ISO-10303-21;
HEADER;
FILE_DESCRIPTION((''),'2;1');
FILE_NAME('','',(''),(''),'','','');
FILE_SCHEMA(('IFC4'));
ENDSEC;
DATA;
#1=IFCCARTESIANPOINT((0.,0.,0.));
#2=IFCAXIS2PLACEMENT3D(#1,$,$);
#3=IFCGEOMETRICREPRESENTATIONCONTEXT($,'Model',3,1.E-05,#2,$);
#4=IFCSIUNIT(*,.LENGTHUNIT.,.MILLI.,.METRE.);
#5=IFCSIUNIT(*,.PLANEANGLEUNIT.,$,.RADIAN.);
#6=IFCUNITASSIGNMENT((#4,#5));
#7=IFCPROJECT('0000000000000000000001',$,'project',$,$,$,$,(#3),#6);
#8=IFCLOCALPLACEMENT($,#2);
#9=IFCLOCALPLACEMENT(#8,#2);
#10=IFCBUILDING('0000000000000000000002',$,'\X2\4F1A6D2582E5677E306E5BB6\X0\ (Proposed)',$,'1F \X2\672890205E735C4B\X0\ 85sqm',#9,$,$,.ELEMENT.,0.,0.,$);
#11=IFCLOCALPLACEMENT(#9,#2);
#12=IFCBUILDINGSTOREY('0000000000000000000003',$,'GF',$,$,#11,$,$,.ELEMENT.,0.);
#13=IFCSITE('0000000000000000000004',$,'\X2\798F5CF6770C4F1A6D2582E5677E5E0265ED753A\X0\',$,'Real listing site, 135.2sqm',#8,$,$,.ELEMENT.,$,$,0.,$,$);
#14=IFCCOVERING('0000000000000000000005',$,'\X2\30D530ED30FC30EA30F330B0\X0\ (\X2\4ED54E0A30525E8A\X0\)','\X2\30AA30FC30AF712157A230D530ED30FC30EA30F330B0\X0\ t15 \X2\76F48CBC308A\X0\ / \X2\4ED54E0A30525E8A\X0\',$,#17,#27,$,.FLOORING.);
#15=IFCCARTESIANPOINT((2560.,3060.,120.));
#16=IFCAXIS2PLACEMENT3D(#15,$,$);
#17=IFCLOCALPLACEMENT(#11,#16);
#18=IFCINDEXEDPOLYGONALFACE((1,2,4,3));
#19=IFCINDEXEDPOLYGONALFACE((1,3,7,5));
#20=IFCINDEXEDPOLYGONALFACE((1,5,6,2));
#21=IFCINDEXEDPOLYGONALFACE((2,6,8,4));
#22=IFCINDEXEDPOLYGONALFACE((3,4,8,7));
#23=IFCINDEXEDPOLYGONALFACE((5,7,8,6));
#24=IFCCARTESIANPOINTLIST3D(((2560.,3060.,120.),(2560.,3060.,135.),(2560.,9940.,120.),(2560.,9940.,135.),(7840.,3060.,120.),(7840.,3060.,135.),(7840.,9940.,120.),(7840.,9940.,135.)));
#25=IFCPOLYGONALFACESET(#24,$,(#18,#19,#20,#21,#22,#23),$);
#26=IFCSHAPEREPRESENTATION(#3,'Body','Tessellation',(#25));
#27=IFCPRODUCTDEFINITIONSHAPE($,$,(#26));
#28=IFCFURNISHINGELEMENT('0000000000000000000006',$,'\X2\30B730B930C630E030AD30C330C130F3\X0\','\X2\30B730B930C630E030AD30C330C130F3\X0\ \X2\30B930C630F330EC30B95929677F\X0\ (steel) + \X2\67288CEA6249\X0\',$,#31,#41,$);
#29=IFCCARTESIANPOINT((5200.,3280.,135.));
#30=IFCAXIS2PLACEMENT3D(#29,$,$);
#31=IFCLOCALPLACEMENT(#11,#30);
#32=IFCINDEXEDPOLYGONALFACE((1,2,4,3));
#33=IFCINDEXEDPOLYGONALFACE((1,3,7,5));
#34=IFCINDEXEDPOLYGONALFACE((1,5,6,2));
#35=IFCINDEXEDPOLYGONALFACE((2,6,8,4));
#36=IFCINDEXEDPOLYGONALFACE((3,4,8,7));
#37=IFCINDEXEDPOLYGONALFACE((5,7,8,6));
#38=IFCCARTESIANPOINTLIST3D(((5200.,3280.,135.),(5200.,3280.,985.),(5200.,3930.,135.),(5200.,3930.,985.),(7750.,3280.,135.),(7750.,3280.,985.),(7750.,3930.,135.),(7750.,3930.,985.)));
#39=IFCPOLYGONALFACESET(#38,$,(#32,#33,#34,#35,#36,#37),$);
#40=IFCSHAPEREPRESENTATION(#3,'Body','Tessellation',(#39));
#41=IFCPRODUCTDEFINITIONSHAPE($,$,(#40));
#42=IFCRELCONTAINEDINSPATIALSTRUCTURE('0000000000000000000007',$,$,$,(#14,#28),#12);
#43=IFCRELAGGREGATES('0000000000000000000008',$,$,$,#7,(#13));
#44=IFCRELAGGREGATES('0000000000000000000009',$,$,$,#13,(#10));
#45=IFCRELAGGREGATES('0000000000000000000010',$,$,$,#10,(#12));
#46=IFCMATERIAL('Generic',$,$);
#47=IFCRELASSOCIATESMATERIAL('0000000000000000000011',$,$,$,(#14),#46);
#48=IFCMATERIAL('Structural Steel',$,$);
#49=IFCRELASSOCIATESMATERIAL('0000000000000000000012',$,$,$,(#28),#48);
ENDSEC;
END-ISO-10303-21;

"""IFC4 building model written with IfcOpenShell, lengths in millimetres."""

from ifc_helpers import new_model, si_unit, frame, frame_2d, origin, place, context, project, spatial, rectangle, extrude, material, element, save


model = new_model("IFC4")

# Units and contexts
model_context = context("Model", 3, precision=1e-05, world=origin())
ifc_project = project(units=[si_unit("LENGTHUNIT", "METRE", prefix="MILLI"), si_unit("PLANEANGLEUNIT", "RADIAN")], contexts=[model_context])

# Site, building, storey
site_placement = place(None, origin())
site = spatial("IfcSite", under=ifc_project, at=site_placement, Name="福島県会津若松市旭町", ObjectType="Real listing site, 135.2sqm", CompositionType="ELEMENT", RefElevation=0.0)
building_placement = place(site_placement, origin())
building = spatial("IfcBuilding", under=site, at=building_placement, Name="会津若松の家 (Proposed)", ObjectType="1F 木造平屋 85sqm", CompositionType="ELEMENT", ElevationOfRefHeight=0.0, ElevationOfTerrain=0.0)
storey_placement = place(building_placement, origin())
storey = spatial("IfcBuildingStorey", under=building, at=storey_placement, Name="GF", CompositionType="ELEMENT", Elevation=0.0)

# Shared definitions
ifc_material_1 = material(Name="Generic")

# Covering
covering_placement = place(storey_placement, frame((2560.0, 3060.0, 120.0)))
element("IfcCovering", 1, at=covering_placement, inside=storey, material=ifc_material_1, Name="フローリング (仕上げ床)", Description="オーク無垢フローリング t15 直貼り / 仕上げ床", PredefinedType="FLOORING", context=model_context, shape_type="SweptSolid", body=[
    extrude(rectangle(XDim=5280.0, YDim=6880.0, at=frame_2d((2640.0, 3440.0))), frame((2560.0, 3060.0, 120.0)), (0.0, 0.0, 1.0), 15.0),
])

# Furnishing element
ifc_material_2 = material(Name="Structural Steel")
furnishing_placement = place(storey_placement, frame((5200.0, 3280.0, 135.0)))
element("IfcFurnishingElement", 2, at=furnishing_placement, inside=storey, material=ifc_material_2, Name="システムキッチン", Description="システムキッチン ステンレス天板 (steel) + 木質扉", context=model_context, shape_type="SweptSolid", body=[
    extrude(rectangle(XDim=2550.0, YDim=650.0, at=frame_2d((1275.0, 325.0))), frame((5200.0, 3280.0, 135.0)), (0.0, 0.0, 1.0), 850.0),
])

save(model, "model.ifc")
